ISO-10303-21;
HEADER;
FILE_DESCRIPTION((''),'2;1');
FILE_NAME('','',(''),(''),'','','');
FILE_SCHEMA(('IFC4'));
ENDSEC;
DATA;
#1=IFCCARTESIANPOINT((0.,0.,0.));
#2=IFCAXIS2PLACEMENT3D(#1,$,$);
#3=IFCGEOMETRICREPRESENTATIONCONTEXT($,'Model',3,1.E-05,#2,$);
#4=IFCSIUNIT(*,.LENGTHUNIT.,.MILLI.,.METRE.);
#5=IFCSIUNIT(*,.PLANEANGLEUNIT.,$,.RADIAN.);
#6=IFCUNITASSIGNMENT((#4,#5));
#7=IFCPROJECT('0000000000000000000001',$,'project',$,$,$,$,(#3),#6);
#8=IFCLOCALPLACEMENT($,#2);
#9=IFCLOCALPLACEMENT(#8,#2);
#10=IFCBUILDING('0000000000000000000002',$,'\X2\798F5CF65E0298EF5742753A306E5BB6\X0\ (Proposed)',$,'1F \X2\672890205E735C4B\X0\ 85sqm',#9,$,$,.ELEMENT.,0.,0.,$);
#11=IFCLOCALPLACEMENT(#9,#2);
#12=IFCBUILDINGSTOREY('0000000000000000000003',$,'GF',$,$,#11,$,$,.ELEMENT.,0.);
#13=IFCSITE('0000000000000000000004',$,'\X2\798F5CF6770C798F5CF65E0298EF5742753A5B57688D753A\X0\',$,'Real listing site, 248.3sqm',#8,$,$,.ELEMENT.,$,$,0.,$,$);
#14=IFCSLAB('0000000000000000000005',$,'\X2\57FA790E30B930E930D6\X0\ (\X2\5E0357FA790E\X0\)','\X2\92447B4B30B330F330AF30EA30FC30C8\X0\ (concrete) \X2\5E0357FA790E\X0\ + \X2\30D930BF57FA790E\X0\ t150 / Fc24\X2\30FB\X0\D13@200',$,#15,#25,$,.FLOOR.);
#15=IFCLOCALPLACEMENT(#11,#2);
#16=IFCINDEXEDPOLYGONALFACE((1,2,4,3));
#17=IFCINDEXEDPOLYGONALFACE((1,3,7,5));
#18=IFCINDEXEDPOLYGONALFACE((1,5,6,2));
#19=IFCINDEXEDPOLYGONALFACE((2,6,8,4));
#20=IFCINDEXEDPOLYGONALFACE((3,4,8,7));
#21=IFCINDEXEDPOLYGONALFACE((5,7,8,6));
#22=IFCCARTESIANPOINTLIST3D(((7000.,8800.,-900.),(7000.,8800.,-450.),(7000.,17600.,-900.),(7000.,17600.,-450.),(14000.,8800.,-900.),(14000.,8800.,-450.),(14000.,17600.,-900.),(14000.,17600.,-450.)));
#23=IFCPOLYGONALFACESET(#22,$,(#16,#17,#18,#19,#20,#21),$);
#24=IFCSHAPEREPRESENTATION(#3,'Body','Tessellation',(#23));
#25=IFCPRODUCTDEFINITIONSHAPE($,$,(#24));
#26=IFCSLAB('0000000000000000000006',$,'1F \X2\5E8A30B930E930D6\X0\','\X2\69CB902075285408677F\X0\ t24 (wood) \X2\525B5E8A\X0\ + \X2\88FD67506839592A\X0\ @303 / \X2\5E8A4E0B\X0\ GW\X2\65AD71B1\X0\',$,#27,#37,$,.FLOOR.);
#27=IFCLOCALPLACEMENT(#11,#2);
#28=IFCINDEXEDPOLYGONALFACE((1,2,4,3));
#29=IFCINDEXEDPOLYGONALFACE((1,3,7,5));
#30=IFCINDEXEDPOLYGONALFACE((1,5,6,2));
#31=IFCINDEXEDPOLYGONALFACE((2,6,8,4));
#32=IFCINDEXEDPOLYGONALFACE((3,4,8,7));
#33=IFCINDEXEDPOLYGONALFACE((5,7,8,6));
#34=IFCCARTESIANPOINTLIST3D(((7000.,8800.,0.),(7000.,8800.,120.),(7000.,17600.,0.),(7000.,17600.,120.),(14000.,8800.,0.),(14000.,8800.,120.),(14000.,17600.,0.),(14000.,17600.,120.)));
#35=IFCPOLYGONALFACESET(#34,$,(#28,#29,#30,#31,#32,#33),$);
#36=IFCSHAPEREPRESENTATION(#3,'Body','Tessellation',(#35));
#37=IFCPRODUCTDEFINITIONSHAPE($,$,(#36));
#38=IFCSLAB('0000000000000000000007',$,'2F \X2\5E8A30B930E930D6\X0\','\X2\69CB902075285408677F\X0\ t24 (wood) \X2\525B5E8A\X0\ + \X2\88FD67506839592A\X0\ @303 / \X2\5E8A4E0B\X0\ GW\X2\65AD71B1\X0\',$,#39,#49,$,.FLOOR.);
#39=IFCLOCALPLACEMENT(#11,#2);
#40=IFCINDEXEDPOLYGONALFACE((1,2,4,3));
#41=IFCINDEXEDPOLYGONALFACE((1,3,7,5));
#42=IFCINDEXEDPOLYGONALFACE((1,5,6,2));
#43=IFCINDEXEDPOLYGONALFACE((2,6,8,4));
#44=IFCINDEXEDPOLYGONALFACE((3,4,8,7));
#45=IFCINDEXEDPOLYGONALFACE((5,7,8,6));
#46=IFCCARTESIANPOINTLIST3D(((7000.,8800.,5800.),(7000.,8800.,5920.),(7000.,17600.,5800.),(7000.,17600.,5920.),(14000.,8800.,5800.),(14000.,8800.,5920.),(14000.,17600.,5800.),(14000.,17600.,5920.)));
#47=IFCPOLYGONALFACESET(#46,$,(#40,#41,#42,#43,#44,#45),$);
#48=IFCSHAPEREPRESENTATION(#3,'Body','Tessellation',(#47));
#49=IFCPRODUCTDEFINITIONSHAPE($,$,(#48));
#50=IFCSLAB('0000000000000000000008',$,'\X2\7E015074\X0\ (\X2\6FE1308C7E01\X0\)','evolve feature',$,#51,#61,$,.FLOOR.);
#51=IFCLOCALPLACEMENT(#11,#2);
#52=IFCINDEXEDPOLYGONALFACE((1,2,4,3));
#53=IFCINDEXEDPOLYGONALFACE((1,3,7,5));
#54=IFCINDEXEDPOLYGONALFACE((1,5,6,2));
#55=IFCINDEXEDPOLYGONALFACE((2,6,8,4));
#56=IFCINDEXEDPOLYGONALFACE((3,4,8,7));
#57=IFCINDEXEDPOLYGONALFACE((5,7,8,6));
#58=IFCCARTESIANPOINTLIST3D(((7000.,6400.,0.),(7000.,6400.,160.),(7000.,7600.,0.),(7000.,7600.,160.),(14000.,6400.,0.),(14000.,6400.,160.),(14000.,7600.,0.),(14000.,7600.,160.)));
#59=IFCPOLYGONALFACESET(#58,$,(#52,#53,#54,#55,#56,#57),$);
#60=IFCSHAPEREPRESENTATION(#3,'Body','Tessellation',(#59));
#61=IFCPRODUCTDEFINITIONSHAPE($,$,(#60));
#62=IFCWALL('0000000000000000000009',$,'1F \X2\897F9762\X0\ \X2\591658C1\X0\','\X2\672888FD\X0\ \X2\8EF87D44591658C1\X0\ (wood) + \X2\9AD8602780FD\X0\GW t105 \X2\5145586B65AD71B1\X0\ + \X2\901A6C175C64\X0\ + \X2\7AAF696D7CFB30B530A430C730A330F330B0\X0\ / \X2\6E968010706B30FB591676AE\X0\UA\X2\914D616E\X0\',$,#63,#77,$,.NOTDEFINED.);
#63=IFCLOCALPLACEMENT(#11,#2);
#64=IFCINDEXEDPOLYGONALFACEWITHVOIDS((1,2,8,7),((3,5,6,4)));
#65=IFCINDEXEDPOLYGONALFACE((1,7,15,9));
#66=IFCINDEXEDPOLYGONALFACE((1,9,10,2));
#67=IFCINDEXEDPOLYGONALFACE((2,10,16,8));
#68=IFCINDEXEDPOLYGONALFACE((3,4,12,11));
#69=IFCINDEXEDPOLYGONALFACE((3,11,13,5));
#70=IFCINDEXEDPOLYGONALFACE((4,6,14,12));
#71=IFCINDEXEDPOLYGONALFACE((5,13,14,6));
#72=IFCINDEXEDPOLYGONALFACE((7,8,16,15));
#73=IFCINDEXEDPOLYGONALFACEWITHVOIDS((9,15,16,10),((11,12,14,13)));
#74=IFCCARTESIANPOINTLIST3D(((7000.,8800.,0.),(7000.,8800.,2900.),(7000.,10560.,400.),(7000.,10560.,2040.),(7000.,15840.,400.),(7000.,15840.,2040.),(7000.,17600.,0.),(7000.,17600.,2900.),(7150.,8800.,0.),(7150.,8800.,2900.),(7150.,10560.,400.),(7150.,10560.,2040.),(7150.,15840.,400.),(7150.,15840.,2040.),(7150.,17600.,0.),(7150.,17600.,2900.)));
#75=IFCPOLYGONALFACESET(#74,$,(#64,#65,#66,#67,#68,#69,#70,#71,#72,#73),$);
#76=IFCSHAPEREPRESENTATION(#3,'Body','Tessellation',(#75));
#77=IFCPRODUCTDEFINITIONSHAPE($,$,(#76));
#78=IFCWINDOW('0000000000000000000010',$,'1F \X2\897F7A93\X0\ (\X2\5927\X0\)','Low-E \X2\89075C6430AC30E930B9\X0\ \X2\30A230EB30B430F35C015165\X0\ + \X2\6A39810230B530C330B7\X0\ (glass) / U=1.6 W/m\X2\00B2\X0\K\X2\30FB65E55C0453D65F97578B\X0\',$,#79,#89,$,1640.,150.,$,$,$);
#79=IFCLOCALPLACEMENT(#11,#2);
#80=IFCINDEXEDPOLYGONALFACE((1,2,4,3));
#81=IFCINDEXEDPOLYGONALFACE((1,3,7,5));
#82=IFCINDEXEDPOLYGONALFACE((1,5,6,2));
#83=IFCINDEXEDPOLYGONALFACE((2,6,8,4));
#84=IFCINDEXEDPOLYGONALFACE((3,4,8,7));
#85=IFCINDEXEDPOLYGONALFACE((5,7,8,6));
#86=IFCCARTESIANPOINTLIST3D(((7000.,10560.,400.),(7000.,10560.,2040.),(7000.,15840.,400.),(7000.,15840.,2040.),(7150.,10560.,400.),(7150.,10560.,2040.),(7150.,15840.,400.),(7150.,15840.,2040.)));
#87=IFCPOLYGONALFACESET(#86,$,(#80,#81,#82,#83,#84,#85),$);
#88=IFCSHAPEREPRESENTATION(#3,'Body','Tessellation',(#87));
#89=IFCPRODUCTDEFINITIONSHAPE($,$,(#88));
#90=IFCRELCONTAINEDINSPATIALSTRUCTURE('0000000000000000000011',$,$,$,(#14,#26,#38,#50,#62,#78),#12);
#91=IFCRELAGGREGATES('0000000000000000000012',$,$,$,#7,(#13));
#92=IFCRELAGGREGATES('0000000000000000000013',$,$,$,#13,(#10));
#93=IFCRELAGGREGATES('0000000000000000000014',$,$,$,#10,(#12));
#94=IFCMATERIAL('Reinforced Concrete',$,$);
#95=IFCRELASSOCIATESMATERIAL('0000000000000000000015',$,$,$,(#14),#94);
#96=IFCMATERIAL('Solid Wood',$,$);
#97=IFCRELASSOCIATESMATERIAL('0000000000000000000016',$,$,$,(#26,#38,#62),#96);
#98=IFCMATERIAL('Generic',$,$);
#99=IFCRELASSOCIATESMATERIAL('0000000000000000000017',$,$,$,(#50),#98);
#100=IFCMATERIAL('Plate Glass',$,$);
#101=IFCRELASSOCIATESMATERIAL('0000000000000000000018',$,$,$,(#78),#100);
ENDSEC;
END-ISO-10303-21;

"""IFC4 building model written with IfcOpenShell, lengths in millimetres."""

from ifc_helpers import new_model, si_unit, frame, frame_2d, origin, place, context, project, spatial, rectangle, extrude, material, element, fill, save


model = new_model("IFC4")

# Units and contexts
model_context = context("Model", 3, precision=1e-05, world=origin())
ifc_project = project(units=[si_unit("LENGTHUNIT", "METRE", prefix="MILLI"), si_unit("PLANEANGLEUNIT", "RADIAN")], contexts=[model_context])

# Site, building, storey
site_placement = place(None, origin())
site = spatial("IfcSite", under=ifc_project, at=site_placement, Name="福島県福島市飯坂町字梍町", ObjectType="Real listing site, 248.3sqm", CompositionType="ELEMENT", RefElevation=0.0)
building_placement = place(site_placement, origin())
building = spatial("IfcBuilding", under=site, at=building_placement, Name="福島市飯坂町の家 (Proposed)", ObjectType="1F 木造平屋 85sqm", CompositionType="ELEMENT", ElevationOfRefHeight=0.0, ElevationOfTerrain=0.0)
storey_placement = place(building_placement, origin())
storey = spatial("IfcBuildingStorey", under=building, at=storey_placement, Name="GF", CompositionType="ELEMENT", Elevation=0.0)

# Slabs
ifc_material_1 = material(Name="Reinforced Concrete")
slab_1_placement = place(storey_placement, frame((3500.0, 4400.0, -450.0)))
element("IfcSlab", 1, at=slab_1_placement, inside=storey, material=ifc_material_1, Name="基礎スラブ (布基礎)", Description="鉄筋コンクリート (concrete) 布基礎 + ベタ基礎 t150 / Fc24・D13@200", PredefinedType="FLOOR", context=model_context, shape_type="SweptSolid", body=[
    extrude(rectangle(XDim=7000.0, YDim=8800.0, at=frame_2d((3500.0, 4400.0))), frame((3500.0, 4400.0, -450.0)), (0.0, 0.0, 1.0), 450.0),
])
ifc_material_2 = material(Name="Solid Wood")
slab_2_placement = place(storey_placement, frame((3500.0, 4400.0, 0.0)))
element("IfcSlab", 2, at=slab_2_placement, inside=storey, material=ifc_material_2, Name="1F 床スラブ", Description="構造用合板 t24 (wood) 剛床 + 製材根太 @303 / 床下 GW断熱", PredefinedType="FLOOR", context=model_context, shape_type="SweptSolid", body=[
    extrude(rectangle(XDim=7000.0, YDim=8800.0, at=frame_2d((3500.0, 4400.0))), frame((3500.0, 4400.0, 0.0)), (0.0, 0.0, 1.0), 120.0),
])
slab_3_placement = place(storey_placement, frame((3500.0, 4400.0, 2900.0)))
element("IfcSlab", 3, at=slab_3_placement, inside=storey, material=ifc_material_2, Name="2F 床スラブ", Description="構造用合板 t24 (wood) 剛床 + 製材根太 @303 / 床下 GW断熱", PredefinedType="FLOOR", context=model_context, shape_type="SweptSolid", body=[
    extrude(rectangle(XDim=7000.0, YDim=8800.0, at=frame_2d((3500.0, 4400.0))), frame((3500.0, 4400.0, 2900.0)), (0.0, 0.0, 1.0), 120.0),
])
ifc_material_3 = material(Name="Generic")
slab_4_placement = place(storey_placement, frame((3500.0, 3200.0, 0.0)))
element("IfcSlab", 4, at=slab_4_placement, inside=storey, material=ifc_material_3, Name="縁側 (濡れ縁)", Description="evolve feature", PredefinedType="FLOOR", context=model_context, shape_type="SweptSolid", body=[
    extrude(rectangle(XDim=7000.0, YDim=1200.0, at=frame_2d((3500.0, 600.0))), frame((3500.0, 3200.0, 0.0)), (0.0, 0.0, 1.0), 160.0),
])

# Shared definitions
ifc_material_4 = material(Name="Plate Glass")

# Wall, opening, window
wall_1_placement = place(storey_placement, frame((3500.0, 4400.0, 0.0)))
wall_1 = element("IfcWall", 5, at=wall_1_placement, inside=storey, material=ifc_material_2, Name="1F 西面 外壁", Description="木製 軸組外壁 (wood) + 高性能GW t105 充填断熱 + 通気層 + 窯業系サイディング / 準耐火・外皮UA配慮", PredefinedType="NOTDEFINED", context=model_context, shape_type="SweptSolid", body=[
    extrude(rectangle(XDim=150.0, YDim=8800.0, at=frame_2d((75.0, 4400.0))), frame((3500.0, 4400.0, 0.0)), (0.0, 0.0, 1.0), 2900.0),
])
opening_1_placement = place(storey_placement, frame((3500.0, 5280.0, 200.0)))
opening_1 = element("IfcOpeningElement", 6, at=opening_1_placement, cuts=wall_1, PredefinedType="NOTDEFINED", context=model_context, shape_type="SweptSolid", body=[
    extrude(rectangle(XDim=150.0, YDim=5280.0, at=frame_2d((75.0, 2640.0))), frame((3500.0, 5280.0, 200.0)), (0.0, 0.0, 1.0), 1640.0),
])
window_1_placement = place(storey_placement, frame((3500.0, 5280.0, 200.0)))
window_1 = element("IfcWindow", 7, at=window_1_placement, inside=storey, material=ifc_material_4, Name="1F 西窓 (大)", Description="Low-E 複層ガラス アルゴン封入 + 樹脂サッシ (glass) / U=1.6 W/m²K・日射取得型", OverallHeight=1640.0, OverallWidth=150.0, context=model_context, shape_type="SweptSolid", body=[
    extrude(rectangle(XDim=150.0, YDim=5280.0, at=frame_2d((75.0, 2640.0))), frame((3500.0, 5280.0, 200.0)), (0.0, 0.0, 1.0), 1640.0),
])
fill(opening_1, window_1)

save(model, "model.ifc")
